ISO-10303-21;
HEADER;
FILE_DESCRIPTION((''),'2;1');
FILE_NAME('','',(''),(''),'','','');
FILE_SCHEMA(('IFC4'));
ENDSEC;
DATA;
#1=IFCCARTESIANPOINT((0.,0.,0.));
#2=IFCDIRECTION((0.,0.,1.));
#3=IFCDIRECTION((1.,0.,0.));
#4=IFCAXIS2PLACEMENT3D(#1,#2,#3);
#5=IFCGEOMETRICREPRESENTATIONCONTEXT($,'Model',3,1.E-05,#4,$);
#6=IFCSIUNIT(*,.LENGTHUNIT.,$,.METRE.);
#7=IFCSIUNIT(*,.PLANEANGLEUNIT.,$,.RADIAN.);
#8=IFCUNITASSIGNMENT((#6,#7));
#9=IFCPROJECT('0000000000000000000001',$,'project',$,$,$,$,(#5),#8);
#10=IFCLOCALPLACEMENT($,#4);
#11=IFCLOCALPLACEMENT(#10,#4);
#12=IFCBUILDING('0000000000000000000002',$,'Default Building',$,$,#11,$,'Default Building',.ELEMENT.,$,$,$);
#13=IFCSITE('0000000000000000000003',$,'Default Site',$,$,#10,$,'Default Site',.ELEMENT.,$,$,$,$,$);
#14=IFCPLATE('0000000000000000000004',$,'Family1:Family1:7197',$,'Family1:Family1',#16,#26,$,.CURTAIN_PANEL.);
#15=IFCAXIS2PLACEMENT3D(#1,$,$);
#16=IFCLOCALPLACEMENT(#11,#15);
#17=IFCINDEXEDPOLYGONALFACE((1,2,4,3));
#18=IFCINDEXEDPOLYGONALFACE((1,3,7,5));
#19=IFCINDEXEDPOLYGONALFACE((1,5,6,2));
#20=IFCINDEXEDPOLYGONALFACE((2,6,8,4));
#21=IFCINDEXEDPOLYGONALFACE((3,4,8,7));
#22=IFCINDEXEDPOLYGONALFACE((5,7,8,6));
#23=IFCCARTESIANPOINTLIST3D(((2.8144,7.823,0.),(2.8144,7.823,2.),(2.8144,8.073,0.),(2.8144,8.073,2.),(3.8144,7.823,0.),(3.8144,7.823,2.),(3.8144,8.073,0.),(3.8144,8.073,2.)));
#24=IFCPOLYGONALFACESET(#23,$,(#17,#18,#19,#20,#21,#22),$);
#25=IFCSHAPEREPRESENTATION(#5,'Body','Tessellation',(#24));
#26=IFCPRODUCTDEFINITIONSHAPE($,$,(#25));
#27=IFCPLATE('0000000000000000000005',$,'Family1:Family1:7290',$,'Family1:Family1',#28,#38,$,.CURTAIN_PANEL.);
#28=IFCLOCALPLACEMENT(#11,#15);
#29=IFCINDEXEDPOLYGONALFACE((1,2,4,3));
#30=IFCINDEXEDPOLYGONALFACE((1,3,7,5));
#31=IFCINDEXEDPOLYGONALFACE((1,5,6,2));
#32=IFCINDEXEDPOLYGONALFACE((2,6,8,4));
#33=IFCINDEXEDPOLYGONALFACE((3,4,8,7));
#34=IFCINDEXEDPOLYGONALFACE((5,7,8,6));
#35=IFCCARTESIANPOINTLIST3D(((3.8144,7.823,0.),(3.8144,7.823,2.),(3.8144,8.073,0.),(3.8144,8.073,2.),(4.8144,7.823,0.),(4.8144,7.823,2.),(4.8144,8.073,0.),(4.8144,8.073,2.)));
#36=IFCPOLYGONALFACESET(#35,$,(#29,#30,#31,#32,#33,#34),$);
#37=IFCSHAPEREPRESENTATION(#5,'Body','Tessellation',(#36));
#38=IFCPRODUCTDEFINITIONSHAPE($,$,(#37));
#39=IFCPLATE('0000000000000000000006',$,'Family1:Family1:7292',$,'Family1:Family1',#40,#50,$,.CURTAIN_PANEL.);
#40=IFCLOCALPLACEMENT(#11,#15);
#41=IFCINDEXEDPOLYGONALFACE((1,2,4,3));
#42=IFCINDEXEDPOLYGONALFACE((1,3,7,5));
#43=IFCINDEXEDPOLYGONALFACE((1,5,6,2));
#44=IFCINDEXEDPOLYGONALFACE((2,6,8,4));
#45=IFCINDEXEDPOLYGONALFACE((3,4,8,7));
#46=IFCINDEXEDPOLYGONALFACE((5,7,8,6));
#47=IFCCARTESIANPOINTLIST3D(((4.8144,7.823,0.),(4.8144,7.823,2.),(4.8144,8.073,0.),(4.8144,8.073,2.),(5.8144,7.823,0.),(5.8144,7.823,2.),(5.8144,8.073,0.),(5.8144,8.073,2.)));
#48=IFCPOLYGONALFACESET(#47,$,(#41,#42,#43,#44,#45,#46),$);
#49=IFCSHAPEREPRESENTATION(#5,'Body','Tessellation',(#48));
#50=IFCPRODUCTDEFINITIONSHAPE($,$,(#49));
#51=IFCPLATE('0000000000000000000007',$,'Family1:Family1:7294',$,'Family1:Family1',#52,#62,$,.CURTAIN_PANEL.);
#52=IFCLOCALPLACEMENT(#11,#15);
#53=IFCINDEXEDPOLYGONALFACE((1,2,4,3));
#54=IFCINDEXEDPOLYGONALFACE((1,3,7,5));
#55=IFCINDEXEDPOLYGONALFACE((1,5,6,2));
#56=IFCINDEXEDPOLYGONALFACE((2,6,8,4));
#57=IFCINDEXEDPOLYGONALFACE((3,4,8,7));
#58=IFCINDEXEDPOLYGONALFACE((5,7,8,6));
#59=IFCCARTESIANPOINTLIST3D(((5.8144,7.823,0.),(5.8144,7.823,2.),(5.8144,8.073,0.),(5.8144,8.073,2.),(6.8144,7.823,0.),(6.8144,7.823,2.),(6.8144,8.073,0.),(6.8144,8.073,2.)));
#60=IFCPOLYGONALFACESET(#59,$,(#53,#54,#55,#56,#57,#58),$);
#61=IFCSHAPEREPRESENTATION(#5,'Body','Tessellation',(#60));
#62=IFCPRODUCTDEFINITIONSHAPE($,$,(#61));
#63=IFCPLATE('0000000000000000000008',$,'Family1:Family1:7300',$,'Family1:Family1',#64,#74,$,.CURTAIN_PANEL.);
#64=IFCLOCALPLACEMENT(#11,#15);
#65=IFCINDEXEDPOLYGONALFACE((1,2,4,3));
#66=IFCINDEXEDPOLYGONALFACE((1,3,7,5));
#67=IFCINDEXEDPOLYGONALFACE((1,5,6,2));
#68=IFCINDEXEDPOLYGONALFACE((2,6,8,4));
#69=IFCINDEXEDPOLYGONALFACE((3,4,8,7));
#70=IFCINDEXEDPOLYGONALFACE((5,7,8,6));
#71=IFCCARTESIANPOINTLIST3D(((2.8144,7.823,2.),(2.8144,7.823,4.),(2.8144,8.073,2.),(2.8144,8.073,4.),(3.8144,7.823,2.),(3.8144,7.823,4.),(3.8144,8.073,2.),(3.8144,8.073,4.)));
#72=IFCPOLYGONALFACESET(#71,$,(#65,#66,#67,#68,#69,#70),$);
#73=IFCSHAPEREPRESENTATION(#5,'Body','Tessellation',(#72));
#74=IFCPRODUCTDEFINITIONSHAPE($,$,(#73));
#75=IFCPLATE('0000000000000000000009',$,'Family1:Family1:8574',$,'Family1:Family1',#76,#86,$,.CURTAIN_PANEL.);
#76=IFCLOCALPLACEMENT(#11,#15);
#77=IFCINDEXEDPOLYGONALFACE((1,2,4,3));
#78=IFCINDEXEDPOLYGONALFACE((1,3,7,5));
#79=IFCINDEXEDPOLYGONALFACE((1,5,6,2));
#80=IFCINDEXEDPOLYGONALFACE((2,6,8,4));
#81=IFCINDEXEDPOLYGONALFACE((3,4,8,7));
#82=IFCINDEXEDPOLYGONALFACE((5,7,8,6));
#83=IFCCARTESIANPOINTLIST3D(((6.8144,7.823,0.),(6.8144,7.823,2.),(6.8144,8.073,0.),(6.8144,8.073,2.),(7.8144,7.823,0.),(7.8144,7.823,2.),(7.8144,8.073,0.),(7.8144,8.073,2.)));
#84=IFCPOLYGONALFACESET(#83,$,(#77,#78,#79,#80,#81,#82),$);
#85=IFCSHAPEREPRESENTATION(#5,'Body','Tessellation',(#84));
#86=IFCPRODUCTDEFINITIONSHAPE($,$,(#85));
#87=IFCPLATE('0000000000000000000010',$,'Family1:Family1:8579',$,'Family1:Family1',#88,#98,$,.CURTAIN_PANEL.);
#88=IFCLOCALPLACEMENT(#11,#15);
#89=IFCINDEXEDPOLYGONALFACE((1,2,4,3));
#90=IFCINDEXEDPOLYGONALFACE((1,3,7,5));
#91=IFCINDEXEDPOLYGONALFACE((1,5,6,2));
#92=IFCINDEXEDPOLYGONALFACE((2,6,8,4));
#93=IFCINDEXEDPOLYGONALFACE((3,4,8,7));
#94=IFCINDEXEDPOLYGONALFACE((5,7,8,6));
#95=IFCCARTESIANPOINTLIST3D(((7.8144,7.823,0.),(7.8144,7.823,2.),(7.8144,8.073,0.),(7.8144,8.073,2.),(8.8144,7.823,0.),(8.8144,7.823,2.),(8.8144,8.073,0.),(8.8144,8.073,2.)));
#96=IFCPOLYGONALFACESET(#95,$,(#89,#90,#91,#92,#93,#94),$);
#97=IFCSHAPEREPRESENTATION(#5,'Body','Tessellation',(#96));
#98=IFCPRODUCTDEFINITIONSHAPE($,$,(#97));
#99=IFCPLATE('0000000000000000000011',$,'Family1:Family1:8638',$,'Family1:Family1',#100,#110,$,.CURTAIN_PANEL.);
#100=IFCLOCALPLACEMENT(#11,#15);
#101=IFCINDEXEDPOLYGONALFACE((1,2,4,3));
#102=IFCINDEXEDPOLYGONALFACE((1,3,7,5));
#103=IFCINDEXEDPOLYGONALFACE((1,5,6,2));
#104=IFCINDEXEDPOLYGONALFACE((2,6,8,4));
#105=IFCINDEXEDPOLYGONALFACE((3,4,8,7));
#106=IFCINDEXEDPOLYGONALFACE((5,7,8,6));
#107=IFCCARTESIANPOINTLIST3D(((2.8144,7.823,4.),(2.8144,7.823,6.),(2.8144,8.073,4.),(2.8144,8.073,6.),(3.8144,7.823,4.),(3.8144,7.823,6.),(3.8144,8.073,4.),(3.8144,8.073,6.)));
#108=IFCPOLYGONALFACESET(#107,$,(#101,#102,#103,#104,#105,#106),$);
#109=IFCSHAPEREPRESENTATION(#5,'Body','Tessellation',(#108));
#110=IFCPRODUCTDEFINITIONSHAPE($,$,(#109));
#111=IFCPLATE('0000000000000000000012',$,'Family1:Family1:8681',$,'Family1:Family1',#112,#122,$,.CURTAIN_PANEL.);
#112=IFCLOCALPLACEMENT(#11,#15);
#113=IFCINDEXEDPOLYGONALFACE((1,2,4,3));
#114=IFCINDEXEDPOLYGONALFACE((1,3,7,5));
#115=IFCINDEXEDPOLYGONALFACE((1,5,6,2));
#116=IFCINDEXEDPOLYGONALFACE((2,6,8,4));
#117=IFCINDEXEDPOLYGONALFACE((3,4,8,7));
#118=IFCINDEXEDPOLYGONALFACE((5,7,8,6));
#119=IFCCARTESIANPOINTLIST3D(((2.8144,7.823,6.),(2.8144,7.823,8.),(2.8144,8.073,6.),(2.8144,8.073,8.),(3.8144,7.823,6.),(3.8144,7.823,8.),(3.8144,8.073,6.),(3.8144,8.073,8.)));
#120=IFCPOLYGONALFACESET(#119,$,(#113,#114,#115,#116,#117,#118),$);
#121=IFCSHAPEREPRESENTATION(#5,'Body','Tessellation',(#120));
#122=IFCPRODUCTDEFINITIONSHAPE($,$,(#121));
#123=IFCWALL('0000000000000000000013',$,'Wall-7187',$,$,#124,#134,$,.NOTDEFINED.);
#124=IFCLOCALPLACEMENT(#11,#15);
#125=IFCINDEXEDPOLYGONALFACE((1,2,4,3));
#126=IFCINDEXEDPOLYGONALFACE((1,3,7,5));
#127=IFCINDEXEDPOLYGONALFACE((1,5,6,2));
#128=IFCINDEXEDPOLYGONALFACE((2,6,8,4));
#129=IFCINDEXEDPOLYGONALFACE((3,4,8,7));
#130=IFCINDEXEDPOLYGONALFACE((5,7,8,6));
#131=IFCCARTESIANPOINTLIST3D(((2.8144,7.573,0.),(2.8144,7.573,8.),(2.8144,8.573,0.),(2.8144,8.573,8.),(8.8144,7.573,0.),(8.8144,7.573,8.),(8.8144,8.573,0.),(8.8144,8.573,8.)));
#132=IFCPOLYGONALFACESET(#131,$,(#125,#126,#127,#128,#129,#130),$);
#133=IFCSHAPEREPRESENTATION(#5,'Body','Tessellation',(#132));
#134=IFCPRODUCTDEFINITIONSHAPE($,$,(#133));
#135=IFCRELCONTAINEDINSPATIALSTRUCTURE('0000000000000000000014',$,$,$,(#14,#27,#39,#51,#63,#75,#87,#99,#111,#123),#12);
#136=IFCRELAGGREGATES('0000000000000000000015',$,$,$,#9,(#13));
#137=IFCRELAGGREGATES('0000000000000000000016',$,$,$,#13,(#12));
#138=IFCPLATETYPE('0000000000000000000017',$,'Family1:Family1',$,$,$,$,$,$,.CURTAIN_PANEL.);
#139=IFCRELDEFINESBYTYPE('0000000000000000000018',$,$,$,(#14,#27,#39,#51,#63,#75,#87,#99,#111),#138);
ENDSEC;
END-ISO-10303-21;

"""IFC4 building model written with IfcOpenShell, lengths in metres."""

from ifc_helpers import new_model, si_unit, frame, origin_with_axes, origin_2d_with_axis, place, context, project, spatial, rectangle, extrude, type_object, element, save


model = new_model("IFC4")

# Units and contexts
model_context = context("Model", 3, precision=1e-05, world=origin_with_axes())
ifc_project = project(units=[si_unit("LENGTHUNIT", "METRE"), si_unit("PLANEANGLEUNIT", "RADIAN")], contexts=[model_context])

# Site, building
site_placement = place(None, origin_with_axes())
site = spatial("IfcSite", under=ifc_project, at=site_placement, Name="Default Site", LongName="Default Site", CompositionType="ELEMENT")
building_placement = place(site_placement, origin_with_axes())
building = spatial("IfcBuilding", under=site, at=building_placement, Name="Default Building", LongName="Default Building", CompositionType="ELEMENT")

# Plates
plate_type = type_object("IfcPlateType", Name="Family1:Family1", PredefinedType="CURTAIN_PANEL")
for number, where, z_axis, x_axis, name in (
    (1, (3.3144, 7.948, 0.0), (0.0, 0.0, 1.0), (1.0, 0.0, 0.0), "Family1:Family1:7197"),
    (2, (4.3144, 7.948, 0.0), (0.0, 0.0, 1.0), (1.0, 0.0, 0.0), "Family1:Family1:7290"),
    (3, (5.3144, 7.948, 0.0), (0.0, 0.0, 1.0), (1.0, 0.0, 0.0), "Family1:Family1:7292"),
    (4, (6.3144, 7.948, 0.0), (0.0, 0.0, 1.0), (1.0, 0.0, 0.0), "Family1:Family1:7294"),
    (5, (3.3144, 7.948, 2.0), (0.0, 0.0, 1.0), (1.0, 0.0, 0.0), "Family1:Family1:7300"),
    (6, (7.3144, 7.948, 0.0), (0.0, 0.0, 1.0), (1.0, 0.0, 0.0), "Family1:Family1:8574"),
    (7, (8.3144, 7.948, 0.0), (0.0, 0.0, 1.0), (1.0, 0.0, 0.0), "Family1:Family1:8579"),
    (8, (3.3144, 7.948, 4.0), (0.0, 0.0, 1.0), (1.0, 0.0, 0.0), "Family1:Family1:8638"),
    (9, (3.3144, 7.948, 6.0), (0.0, 0.0, 1.0), (1.0, 0.0, 0.0), "Family1:Family1:8681"),
):
    element("IfcPlate", number, at=place(building_placement, frame(where, z_axis=z_axis, x_axis=x_axis)), inside=building, type_object=plate_type, Name=name, ObjectType="Family1:Family1", PredefinedType="CURTAIN_PANEL", context=model_context, shape_type="SweptSolid", body=[
        extrude(rectangle(XDim=1.0, YDim=0.25, at=origin_2d_with_axis()), origin_with_axes(), (0.0, 0.0, 1.0), 2.0),
    ])

# Wall
wall_1_placement = place(building_placement, frame((5.8144, 8.073, 0.0), z_axis=(0.0, 0.0, 1.0), x_axis=(1.0, 0.0, 0.0)))
element("IfcWall", 10, at=wall_1_placement, inside=building, Name="Wall-7187", PredefinedType="NOTDEFINED", context=model_context, shape_type="SweptSolid", body=[
    extrude(rectangle(XDim=6.0, YDim=1.0, at=origin_2d_with_axis()), origin_with_axes(), (0.0, 0.0, 1.0), 8.0),
])

save(model, "model.ifc")
